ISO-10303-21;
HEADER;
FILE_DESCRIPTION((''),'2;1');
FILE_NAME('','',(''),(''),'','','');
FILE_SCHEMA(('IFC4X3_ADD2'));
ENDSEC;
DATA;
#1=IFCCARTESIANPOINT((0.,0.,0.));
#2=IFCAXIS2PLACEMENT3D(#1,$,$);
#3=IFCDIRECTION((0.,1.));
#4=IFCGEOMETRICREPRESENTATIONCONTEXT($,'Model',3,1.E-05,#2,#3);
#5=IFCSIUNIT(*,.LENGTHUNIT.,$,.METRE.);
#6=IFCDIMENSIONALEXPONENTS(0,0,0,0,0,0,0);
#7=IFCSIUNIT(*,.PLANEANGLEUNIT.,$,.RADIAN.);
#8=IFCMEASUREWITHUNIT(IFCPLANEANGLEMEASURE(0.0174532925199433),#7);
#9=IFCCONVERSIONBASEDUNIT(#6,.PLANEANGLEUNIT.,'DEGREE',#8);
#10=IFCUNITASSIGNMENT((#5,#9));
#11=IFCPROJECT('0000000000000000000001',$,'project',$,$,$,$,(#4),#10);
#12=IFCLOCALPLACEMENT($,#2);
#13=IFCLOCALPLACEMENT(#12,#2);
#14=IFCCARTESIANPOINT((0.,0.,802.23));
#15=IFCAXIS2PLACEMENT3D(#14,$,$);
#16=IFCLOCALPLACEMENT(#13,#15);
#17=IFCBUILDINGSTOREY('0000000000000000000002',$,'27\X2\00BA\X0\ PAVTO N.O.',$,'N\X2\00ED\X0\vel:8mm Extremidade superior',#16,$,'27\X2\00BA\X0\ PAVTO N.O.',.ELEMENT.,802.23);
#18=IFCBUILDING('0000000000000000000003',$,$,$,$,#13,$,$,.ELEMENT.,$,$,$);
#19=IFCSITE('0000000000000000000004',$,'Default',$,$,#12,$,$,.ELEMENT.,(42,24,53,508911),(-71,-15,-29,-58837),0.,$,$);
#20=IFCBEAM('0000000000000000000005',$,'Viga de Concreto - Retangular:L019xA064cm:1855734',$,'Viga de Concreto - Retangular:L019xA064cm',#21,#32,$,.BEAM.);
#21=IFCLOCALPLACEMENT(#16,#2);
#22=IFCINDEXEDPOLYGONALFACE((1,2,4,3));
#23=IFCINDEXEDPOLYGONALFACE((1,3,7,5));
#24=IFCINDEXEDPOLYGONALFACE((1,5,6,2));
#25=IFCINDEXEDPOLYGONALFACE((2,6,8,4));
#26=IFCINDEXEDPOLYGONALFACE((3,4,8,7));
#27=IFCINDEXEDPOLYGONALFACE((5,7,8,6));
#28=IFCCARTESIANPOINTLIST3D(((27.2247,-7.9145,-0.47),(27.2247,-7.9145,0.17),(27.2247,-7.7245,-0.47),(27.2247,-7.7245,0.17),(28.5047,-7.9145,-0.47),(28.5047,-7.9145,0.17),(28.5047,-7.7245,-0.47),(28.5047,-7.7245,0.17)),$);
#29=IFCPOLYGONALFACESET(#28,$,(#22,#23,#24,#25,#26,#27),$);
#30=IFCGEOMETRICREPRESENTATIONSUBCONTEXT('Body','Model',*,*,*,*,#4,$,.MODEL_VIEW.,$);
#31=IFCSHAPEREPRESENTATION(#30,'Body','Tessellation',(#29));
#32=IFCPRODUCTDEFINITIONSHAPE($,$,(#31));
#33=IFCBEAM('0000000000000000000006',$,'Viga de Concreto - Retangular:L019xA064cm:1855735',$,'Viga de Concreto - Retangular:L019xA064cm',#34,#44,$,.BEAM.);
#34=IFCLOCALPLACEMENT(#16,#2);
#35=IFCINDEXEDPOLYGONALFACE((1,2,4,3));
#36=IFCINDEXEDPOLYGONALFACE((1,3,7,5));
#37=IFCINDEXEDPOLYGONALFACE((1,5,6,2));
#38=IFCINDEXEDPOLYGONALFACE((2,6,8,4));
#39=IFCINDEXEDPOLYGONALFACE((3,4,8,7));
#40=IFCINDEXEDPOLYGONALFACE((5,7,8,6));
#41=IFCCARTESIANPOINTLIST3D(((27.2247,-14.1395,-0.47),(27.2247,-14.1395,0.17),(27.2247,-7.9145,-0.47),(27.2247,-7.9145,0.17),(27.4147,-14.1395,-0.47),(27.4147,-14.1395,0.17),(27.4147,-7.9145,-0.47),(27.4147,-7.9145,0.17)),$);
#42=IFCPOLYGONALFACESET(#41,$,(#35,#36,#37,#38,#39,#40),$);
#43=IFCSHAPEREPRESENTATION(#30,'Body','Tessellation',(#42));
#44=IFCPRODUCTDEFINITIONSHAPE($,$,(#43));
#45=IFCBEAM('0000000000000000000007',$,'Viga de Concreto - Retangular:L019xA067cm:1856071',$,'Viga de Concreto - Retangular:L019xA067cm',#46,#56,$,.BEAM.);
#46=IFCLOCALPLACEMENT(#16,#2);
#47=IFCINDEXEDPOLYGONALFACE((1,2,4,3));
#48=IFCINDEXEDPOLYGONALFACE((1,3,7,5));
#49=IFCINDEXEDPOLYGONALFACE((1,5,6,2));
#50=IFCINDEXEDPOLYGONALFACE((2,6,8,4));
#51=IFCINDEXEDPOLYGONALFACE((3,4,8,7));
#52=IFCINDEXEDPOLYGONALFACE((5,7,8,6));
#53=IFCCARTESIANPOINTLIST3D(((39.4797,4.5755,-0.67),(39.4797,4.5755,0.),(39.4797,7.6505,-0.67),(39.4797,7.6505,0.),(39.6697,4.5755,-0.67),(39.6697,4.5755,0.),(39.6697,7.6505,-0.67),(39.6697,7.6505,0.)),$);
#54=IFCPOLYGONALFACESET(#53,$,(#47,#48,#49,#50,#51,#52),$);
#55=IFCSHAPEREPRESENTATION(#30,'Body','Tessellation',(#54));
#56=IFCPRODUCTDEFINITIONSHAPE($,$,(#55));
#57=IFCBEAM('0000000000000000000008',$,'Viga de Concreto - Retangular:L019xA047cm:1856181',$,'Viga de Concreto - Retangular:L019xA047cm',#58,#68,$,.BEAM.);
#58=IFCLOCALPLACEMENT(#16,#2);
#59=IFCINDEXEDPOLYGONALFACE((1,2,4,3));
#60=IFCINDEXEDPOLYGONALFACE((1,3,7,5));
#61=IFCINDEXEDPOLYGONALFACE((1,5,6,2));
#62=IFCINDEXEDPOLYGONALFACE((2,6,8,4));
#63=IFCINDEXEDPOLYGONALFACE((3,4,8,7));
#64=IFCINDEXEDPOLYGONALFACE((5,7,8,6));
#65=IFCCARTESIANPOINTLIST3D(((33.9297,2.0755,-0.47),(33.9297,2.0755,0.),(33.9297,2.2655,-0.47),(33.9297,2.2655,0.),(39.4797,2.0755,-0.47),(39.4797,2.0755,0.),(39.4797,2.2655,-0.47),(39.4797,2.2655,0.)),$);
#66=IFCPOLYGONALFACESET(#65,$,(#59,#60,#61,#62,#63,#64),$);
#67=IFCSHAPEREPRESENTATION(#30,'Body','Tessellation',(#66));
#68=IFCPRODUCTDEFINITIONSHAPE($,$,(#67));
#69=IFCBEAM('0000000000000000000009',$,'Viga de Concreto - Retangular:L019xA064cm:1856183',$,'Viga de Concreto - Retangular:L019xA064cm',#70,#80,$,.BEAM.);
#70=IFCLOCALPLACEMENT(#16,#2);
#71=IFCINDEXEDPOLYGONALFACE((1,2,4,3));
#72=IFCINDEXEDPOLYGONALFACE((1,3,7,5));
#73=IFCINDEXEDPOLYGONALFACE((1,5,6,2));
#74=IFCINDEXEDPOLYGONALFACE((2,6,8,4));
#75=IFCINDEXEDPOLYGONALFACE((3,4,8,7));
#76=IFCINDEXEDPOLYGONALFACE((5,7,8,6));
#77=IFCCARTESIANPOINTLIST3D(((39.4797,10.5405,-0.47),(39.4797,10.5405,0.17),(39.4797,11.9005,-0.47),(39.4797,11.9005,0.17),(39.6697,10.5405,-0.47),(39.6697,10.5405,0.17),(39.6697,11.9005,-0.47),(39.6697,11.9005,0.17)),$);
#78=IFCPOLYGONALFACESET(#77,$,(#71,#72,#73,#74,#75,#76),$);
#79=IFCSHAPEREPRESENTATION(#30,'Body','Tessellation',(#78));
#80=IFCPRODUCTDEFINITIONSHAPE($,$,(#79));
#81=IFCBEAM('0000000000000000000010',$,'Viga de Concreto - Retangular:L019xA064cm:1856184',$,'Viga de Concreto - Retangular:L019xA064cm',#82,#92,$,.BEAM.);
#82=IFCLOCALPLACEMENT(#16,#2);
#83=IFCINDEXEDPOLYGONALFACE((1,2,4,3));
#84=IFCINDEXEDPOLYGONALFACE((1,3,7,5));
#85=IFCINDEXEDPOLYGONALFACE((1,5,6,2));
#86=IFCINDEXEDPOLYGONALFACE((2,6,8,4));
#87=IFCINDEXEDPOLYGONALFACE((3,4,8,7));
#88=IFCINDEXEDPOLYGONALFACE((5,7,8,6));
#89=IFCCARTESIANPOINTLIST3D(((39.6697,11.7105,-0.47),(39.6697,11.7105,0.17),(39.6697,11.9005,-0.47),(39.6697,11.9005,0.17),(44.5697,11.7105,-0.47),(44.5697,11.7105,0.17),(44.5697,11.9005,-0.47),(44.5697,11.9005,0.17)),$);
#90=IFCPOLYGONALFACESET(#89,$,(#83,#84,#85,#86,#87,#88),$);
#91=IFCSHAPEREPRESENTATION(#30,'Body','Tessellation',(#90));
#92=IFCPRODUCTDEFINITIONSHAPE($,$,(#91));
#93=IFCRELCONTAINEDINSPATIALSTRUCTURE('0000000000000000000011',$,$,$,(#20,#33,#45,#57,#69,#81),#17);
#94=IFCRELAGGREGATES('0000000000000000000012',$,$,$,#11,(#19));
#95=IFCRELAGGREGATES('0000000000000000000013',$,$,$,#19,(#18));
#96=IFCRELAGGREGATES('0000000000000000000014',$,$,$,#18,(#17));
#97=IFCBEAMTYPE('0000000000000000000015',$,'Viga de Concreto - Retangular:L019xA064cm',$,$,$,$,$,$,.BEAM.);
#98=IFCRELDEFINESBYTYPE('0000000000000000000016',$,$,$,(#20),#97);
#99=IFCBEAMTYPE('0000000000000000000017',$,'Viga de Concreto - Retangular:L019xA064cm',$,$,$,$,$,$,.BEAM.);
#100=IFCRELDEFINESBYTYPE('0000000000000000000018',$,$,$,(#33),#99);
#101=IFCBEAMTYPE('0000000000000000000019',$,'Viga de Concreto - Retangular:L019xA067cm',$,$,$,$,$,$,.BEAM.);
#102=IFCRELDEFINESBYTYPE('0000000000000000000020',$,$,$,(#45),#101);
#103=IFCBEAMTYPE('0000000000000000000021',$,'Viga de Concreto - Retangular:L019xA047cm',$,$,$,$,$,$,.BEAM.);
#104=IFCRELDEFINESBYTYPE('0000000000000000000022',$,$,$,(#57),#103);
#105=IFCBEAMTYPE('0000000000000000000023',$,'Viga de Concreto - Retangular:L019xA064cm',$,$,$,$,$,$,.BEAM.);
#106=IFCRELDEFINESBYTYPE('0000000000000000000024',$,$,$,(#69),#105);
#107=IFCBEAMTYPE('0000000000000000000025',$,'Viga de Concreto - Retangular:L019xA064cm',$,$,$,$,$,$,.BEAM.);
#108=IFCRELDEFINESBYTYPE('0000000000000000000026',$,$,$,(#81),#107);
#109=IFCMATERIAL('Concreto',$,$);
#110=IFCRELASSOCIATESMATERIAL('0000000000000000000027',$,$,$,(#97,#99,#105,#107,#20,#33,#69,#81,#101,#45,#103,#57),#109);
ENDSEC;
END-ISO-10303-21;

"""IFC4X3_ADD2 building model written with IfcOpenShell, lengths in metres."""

from ifc_helpers import new_model, entity, si_unit, converted_unit, direction, frame, frame_2d, origin, place, context, subcontext, project, spatial, rectangle, extrude, source, transform, mapped, material, material_profile, profile_set, profile_usage, type_object, type_shapes, element, save


model = new_model("IFC4X3_ADD2")

# Units and contexts
model_context = context("Model", 3, precision=1e-05, world=origin(), true_north=direction((0.0, 1.0)))
body_context = subcontext(model_context, "Body", "Model", "MODEL_VIEW")
ifc_project = project(units=[si_unit("LENGTHUNIT", "METRE"), converted_unit("PLANEANGLEUNIT", "DEGREE", entity("IfcPlaneAngleMeasure", 0.0174532925199433), si_unit("PLANEANGLEUNIT", "RADIAN"), dimensions=[0, 0, 0, 0, 0, 0, 0])], contexts=[model_context])

# Site, building, storey
site_placement = place(None, origin())
site = spatial("IfcSite", under=ifc_project, at=site_placement, Name="Default", CompositionType="ELEMENT", RefLatitude=(42, 24, 53, 508911), RefLongitude=(-71, -15, -29, -58837), RefElevation=0.0)
building_placement = place(site_placement, origin())
building = spatial("IfcBuilding", under=site, at=building_placement, CompositionType="ELEMENT")
storey_placement = place(building_placement, frame((0.0, 0.0, 802.23)))
storey = spatial("IfcBuildingStorey", under=building, at=storey_placement, Name="27º PAVTO N.O.", ObjectType="Nível:8mm Extremidade superior", LongName="27º PAVTO N.O.", CompositionType="ELEMENT", Elevation=802.23)

# Beams
ifc_material = material(Name="Concreto")
ifc_material_profile_1 = material_profile(ifc_material, rectangle(XDim=0.64, YDim=0.19, at=frame_2d((0.0, 0.0), x_axis=(1.0, 0.0))), Name="L019xA064cm")
ifc_profile_set_1 = profile_set([ifc_material_profile_1], Name="L019xA064cm")
ifc_profile_usage_1 = profile_usage(ifc_profile_set_1, cardinal=8)
beam_type_1 = type_object("IfcBeamType", Name="Viga de Concreto - Retangular:L019xA064cm", PredefinedType="BEAM", material=ifc_profile_set_1)
shared_shape_1 = source(origin(), body_context, "Body", "SweptSolid", [
    extrude(rectangle(XDim=0.64, YDim=0.19, at=frame_2d((0.0, 0.0), x_axis=(1.0, 0.0))), frame((28.5047, -7.8195, 802.08), z_axis=(-1.0, 0.0, 0.0), x_axis=(0.0, 0.0, -1.0)), (0.0, 0.0, 1.0), 1.28),
])
type_shapes(beam_type_1, [shared_shape_1])
beam_1_placement = place(storey_placement, frame((0.0, 0.0, -802.23)))
element("IfcBeam", 1, at=beam_1_placement, inside=storey, type_object=beam_type_1, material=ifc_profile_usage_1, Name="Viga de Concreto - Retangular:L019xA064cm:1855734", ObjectType="Viga de Concreto - Retangular:L019xA064cm", PredefinedType="BEAM", context=body_context, shape_type="MappedRepresentation", body=[
    mapped(shared_shape_1, transform((0.0, 0.0, 0.0), scale=1.0)),
])
beam_type_2 = type_object("IfcBeamType", Name="Viga de Concreto - Retangular:L019xA064cm", PredefinedType="BEAM", material=ifc_profile_set_1)
shared_shape_2 = source(origin(), body_context, "Body", "SweptSolid", [
    extrude(rectangle(XDim=0.64, YDim=0.19, at=frame_2d((0.0, 0.0), x_axis=(0.0, 1.0))), frame((27.3197, -14.1395, 802.08), z_axis=(0.0, 1.0, 0.0), x_axis=(-1.0, 0.0, 0.0)), (0.0, 0.0, 1.0), 6.225),
])
type_shapes(beam_type_2, [shared_shape_2])
beam_2_placement = place(storey_placement, frame((0.0, 0.0, -802.23)))
element("IfcBeam", 2, at=beam_2_placement, inside=storey, type_object=beam_type_2, material=ifc_profile_usage_1, Name="Viga de Concreto - Retangular:L019xA064cm:1855735", ObjectType="Viga de Concreto - Retangular:L019xA064cm", PredefinedType="BEAM", context=body_context, shape_type="MappedRepresentation", body=[
    mapped(shared_shape_2, transform((0.0, 0.0, 0.0), scale=1.0)),
])
ifc_material_profile_2 = material_profile(ifc_material, rectangle(XDim=0.67, YDim=0.19, at=frame_2d((0.0, 0.0), x_axis=(0.0, 1.0))), Name="L019xA067cm")
ifc_profile_set_2 = profile_set([ifc_material_profile_2], Name="L019xA067cm")
ifc_profile_usage_2 = profile_usage(ifc_profile_set_2, cardinal=8)
beam_type_3 = type_object("IfcBeamType", Name="Viga de Concreto - Retangular:L019xA067cm", PredefinedType="BEAM", material=ifc_profile_set_2)
shared_shape_3 = source(origin(), body_context, "Body", "SweptSolid", [
    extrude(rectangle(XDim=0.67, YDim=0.19, at=frame_2d((0.0, 0.0), x_axis=(0.0, 1.0))), frame((39.5747, 4.5755, 801.895), z_axis=(0.0, 1.0, 0.0), x_axis=(-1.0, 0.0, 0.0)), (0.0, 0.0, 1.0), 3.075),
])
type_shapes(beam_type_3, [shared_shape_3])
beam_3_placement = place(storey_placement, frame((0.0, 0.0, -802.23)))
element("IfcBeam", 3, at=beam_3_placement, inside=storey, type_object=beam_type_3, material=ifc_profile_usage_2, Name="Viga de Concreto - Retangular:L019xA067cm:1856071", ObjectType="Viga de Concreto - Retangular:L019xA067cm", PredefinedType="BEAM", context=body_context, shape_type="MappedRepresentation", body=[
    mapped(shared_shape_3, transform((0.0, 0.0, 0.0), scale=1.0)),
])
ifc_material_profile_3 = material_profile(ifc_material, rectangle(XDim=0.47, YDim=0.19, at=frame_2d((0.0, 0.0), x_axis=(0.0, 1.0))), Name="L019xA047cm")
ifc_profile_set_3 = profile_set([ifc_material_profile_3], Name="L019xA047cm")
ifc_profile_usage_3 = profile_usage(ifc_profile_set_3, cardinal=8)
beam_type_4 = type_object("IfcBeamType", Name="Viga de Concreto - Retangular:L019xA047cm", PredefinedType="BEAM", material=ifc_profile_set_3)
shared_shape_4 = source(origin(), body_context, "Body", "SweptSolid", [
    extrude(rectangle(XDim=0.47, YDim=0.19, at=frame_2d((0.0, 0.0), x_axis=(1.0, 0.0))), frame((33.9297, 2.1705, 801.995), z_axis=(1.0, 0.0, 0.0), x_axis=(0.0, 0.0, -1.0)), (0.0, 0.0, 1.0), 5.55),
])
type_shapes(beam_type_4, [shared_shape_4])
beam_4_placement = place(storey_placement, frame((0.0, 0.0, -802.23)))
element("IfcBeam", 4, at=beam_4_placement, inside=storey, type_object=beam_type_4, material=ifc_profile_usage_3, Name="Viga de Concreto - Retangular:L019xA047cm:1856181", ObjectType="Viga de Concreto - Retangular:L019xA047cm", PredefinedType="BEAM", context=body_context, shape_type="MappedRepresentation", body=[
    mapped(shared_shape_4, transform((0.0, 0.0, 0.0), scale=1.0)),
])
beam_type_5 = type_object("IfcBeamType", Name="Viga de Concreto - Retangular:L019xA064cm", PredefinedType="BEAM", material=ifc_profile_set_1)
shared_shape_5 = source(origin(), body_context, "Body", "SweptSolid", [
    extrude(rectangle(XDim=0.64, YDim=0.19, at=frame_2d((0.0, 0.0), x_axis=(0.0, 1.0))), frame((39.5747, 11.9005, 802.08), z_axis=(0.0, -1.0, 0.0), x_axis=(-1.0, 0.0, 0.0)), (0.0, 0.0, 1.0), 1.36),
])
type_shapes(beam_type_5, [shared_shape_5])
beam_5_placement = place(storey_placement, frame((0.0, 0.0, -802.23)))
element("IfcBeam", 5, at=beam_5_placement, inside=storey, type_object=beam_type_5, material=ifc_profile_usage_1, Name="Viga de Concreto - Retangular:L019xA064cm:1856183", ObjectType="Viga de Concreto - Retangular:L019xA064cm", PredefinedType="BEAM", context=body_context, shape_type="MappedRepresentation", body=[
    mapped(shared_shape_5, transform((0.0, 0.0, 0.0), scale=1.0)),
])
beam_type_6 = type_object("IfcBeamType", Name="Viga de Concreto - Retangular:L019xA064cm", PredefinedType="BEAM", material=ifc_profile_set_1)
shared_shape_6 = source(origin(), body_context, "Body", "SweptSolid", [
    extrude(rectangle(XDim=0.64, YDim=0.19, at=frame_2d((0.0, 0.0), x_axis=(1.0, 0.0))), frame((39.6697, 11.8055, 802.08), z_axis=(1.0, 0.0, 0.0), x_axis=(0.0, 0.0, -1.0)), (0.0, 0.0, 1.0), 4.9),
])
type_shapes(beam_type_6, [shared_shape_6])
beam_6_placement = place(storey_placement, frame((0.0, 0.0, -802.23)))
element("IfcBeam", 6, at=beam_6_placement, inside=storey, type_object=beam_type_6, material=ifc_profile_usage_1, Name="Viga de Concreto - Retangular:L019xA064cm:1856184", ObjectType="Viga de Concreto - Retangular:L019xA064cm", PredefinedType="BEAM", context=body_context, shape_type="MappedRepresentation", body=[
    mapped(shared_shape_6, transform((0.0, 0.0, 0.0), scale=1.0)),
])

save(model, "model.ifc")
